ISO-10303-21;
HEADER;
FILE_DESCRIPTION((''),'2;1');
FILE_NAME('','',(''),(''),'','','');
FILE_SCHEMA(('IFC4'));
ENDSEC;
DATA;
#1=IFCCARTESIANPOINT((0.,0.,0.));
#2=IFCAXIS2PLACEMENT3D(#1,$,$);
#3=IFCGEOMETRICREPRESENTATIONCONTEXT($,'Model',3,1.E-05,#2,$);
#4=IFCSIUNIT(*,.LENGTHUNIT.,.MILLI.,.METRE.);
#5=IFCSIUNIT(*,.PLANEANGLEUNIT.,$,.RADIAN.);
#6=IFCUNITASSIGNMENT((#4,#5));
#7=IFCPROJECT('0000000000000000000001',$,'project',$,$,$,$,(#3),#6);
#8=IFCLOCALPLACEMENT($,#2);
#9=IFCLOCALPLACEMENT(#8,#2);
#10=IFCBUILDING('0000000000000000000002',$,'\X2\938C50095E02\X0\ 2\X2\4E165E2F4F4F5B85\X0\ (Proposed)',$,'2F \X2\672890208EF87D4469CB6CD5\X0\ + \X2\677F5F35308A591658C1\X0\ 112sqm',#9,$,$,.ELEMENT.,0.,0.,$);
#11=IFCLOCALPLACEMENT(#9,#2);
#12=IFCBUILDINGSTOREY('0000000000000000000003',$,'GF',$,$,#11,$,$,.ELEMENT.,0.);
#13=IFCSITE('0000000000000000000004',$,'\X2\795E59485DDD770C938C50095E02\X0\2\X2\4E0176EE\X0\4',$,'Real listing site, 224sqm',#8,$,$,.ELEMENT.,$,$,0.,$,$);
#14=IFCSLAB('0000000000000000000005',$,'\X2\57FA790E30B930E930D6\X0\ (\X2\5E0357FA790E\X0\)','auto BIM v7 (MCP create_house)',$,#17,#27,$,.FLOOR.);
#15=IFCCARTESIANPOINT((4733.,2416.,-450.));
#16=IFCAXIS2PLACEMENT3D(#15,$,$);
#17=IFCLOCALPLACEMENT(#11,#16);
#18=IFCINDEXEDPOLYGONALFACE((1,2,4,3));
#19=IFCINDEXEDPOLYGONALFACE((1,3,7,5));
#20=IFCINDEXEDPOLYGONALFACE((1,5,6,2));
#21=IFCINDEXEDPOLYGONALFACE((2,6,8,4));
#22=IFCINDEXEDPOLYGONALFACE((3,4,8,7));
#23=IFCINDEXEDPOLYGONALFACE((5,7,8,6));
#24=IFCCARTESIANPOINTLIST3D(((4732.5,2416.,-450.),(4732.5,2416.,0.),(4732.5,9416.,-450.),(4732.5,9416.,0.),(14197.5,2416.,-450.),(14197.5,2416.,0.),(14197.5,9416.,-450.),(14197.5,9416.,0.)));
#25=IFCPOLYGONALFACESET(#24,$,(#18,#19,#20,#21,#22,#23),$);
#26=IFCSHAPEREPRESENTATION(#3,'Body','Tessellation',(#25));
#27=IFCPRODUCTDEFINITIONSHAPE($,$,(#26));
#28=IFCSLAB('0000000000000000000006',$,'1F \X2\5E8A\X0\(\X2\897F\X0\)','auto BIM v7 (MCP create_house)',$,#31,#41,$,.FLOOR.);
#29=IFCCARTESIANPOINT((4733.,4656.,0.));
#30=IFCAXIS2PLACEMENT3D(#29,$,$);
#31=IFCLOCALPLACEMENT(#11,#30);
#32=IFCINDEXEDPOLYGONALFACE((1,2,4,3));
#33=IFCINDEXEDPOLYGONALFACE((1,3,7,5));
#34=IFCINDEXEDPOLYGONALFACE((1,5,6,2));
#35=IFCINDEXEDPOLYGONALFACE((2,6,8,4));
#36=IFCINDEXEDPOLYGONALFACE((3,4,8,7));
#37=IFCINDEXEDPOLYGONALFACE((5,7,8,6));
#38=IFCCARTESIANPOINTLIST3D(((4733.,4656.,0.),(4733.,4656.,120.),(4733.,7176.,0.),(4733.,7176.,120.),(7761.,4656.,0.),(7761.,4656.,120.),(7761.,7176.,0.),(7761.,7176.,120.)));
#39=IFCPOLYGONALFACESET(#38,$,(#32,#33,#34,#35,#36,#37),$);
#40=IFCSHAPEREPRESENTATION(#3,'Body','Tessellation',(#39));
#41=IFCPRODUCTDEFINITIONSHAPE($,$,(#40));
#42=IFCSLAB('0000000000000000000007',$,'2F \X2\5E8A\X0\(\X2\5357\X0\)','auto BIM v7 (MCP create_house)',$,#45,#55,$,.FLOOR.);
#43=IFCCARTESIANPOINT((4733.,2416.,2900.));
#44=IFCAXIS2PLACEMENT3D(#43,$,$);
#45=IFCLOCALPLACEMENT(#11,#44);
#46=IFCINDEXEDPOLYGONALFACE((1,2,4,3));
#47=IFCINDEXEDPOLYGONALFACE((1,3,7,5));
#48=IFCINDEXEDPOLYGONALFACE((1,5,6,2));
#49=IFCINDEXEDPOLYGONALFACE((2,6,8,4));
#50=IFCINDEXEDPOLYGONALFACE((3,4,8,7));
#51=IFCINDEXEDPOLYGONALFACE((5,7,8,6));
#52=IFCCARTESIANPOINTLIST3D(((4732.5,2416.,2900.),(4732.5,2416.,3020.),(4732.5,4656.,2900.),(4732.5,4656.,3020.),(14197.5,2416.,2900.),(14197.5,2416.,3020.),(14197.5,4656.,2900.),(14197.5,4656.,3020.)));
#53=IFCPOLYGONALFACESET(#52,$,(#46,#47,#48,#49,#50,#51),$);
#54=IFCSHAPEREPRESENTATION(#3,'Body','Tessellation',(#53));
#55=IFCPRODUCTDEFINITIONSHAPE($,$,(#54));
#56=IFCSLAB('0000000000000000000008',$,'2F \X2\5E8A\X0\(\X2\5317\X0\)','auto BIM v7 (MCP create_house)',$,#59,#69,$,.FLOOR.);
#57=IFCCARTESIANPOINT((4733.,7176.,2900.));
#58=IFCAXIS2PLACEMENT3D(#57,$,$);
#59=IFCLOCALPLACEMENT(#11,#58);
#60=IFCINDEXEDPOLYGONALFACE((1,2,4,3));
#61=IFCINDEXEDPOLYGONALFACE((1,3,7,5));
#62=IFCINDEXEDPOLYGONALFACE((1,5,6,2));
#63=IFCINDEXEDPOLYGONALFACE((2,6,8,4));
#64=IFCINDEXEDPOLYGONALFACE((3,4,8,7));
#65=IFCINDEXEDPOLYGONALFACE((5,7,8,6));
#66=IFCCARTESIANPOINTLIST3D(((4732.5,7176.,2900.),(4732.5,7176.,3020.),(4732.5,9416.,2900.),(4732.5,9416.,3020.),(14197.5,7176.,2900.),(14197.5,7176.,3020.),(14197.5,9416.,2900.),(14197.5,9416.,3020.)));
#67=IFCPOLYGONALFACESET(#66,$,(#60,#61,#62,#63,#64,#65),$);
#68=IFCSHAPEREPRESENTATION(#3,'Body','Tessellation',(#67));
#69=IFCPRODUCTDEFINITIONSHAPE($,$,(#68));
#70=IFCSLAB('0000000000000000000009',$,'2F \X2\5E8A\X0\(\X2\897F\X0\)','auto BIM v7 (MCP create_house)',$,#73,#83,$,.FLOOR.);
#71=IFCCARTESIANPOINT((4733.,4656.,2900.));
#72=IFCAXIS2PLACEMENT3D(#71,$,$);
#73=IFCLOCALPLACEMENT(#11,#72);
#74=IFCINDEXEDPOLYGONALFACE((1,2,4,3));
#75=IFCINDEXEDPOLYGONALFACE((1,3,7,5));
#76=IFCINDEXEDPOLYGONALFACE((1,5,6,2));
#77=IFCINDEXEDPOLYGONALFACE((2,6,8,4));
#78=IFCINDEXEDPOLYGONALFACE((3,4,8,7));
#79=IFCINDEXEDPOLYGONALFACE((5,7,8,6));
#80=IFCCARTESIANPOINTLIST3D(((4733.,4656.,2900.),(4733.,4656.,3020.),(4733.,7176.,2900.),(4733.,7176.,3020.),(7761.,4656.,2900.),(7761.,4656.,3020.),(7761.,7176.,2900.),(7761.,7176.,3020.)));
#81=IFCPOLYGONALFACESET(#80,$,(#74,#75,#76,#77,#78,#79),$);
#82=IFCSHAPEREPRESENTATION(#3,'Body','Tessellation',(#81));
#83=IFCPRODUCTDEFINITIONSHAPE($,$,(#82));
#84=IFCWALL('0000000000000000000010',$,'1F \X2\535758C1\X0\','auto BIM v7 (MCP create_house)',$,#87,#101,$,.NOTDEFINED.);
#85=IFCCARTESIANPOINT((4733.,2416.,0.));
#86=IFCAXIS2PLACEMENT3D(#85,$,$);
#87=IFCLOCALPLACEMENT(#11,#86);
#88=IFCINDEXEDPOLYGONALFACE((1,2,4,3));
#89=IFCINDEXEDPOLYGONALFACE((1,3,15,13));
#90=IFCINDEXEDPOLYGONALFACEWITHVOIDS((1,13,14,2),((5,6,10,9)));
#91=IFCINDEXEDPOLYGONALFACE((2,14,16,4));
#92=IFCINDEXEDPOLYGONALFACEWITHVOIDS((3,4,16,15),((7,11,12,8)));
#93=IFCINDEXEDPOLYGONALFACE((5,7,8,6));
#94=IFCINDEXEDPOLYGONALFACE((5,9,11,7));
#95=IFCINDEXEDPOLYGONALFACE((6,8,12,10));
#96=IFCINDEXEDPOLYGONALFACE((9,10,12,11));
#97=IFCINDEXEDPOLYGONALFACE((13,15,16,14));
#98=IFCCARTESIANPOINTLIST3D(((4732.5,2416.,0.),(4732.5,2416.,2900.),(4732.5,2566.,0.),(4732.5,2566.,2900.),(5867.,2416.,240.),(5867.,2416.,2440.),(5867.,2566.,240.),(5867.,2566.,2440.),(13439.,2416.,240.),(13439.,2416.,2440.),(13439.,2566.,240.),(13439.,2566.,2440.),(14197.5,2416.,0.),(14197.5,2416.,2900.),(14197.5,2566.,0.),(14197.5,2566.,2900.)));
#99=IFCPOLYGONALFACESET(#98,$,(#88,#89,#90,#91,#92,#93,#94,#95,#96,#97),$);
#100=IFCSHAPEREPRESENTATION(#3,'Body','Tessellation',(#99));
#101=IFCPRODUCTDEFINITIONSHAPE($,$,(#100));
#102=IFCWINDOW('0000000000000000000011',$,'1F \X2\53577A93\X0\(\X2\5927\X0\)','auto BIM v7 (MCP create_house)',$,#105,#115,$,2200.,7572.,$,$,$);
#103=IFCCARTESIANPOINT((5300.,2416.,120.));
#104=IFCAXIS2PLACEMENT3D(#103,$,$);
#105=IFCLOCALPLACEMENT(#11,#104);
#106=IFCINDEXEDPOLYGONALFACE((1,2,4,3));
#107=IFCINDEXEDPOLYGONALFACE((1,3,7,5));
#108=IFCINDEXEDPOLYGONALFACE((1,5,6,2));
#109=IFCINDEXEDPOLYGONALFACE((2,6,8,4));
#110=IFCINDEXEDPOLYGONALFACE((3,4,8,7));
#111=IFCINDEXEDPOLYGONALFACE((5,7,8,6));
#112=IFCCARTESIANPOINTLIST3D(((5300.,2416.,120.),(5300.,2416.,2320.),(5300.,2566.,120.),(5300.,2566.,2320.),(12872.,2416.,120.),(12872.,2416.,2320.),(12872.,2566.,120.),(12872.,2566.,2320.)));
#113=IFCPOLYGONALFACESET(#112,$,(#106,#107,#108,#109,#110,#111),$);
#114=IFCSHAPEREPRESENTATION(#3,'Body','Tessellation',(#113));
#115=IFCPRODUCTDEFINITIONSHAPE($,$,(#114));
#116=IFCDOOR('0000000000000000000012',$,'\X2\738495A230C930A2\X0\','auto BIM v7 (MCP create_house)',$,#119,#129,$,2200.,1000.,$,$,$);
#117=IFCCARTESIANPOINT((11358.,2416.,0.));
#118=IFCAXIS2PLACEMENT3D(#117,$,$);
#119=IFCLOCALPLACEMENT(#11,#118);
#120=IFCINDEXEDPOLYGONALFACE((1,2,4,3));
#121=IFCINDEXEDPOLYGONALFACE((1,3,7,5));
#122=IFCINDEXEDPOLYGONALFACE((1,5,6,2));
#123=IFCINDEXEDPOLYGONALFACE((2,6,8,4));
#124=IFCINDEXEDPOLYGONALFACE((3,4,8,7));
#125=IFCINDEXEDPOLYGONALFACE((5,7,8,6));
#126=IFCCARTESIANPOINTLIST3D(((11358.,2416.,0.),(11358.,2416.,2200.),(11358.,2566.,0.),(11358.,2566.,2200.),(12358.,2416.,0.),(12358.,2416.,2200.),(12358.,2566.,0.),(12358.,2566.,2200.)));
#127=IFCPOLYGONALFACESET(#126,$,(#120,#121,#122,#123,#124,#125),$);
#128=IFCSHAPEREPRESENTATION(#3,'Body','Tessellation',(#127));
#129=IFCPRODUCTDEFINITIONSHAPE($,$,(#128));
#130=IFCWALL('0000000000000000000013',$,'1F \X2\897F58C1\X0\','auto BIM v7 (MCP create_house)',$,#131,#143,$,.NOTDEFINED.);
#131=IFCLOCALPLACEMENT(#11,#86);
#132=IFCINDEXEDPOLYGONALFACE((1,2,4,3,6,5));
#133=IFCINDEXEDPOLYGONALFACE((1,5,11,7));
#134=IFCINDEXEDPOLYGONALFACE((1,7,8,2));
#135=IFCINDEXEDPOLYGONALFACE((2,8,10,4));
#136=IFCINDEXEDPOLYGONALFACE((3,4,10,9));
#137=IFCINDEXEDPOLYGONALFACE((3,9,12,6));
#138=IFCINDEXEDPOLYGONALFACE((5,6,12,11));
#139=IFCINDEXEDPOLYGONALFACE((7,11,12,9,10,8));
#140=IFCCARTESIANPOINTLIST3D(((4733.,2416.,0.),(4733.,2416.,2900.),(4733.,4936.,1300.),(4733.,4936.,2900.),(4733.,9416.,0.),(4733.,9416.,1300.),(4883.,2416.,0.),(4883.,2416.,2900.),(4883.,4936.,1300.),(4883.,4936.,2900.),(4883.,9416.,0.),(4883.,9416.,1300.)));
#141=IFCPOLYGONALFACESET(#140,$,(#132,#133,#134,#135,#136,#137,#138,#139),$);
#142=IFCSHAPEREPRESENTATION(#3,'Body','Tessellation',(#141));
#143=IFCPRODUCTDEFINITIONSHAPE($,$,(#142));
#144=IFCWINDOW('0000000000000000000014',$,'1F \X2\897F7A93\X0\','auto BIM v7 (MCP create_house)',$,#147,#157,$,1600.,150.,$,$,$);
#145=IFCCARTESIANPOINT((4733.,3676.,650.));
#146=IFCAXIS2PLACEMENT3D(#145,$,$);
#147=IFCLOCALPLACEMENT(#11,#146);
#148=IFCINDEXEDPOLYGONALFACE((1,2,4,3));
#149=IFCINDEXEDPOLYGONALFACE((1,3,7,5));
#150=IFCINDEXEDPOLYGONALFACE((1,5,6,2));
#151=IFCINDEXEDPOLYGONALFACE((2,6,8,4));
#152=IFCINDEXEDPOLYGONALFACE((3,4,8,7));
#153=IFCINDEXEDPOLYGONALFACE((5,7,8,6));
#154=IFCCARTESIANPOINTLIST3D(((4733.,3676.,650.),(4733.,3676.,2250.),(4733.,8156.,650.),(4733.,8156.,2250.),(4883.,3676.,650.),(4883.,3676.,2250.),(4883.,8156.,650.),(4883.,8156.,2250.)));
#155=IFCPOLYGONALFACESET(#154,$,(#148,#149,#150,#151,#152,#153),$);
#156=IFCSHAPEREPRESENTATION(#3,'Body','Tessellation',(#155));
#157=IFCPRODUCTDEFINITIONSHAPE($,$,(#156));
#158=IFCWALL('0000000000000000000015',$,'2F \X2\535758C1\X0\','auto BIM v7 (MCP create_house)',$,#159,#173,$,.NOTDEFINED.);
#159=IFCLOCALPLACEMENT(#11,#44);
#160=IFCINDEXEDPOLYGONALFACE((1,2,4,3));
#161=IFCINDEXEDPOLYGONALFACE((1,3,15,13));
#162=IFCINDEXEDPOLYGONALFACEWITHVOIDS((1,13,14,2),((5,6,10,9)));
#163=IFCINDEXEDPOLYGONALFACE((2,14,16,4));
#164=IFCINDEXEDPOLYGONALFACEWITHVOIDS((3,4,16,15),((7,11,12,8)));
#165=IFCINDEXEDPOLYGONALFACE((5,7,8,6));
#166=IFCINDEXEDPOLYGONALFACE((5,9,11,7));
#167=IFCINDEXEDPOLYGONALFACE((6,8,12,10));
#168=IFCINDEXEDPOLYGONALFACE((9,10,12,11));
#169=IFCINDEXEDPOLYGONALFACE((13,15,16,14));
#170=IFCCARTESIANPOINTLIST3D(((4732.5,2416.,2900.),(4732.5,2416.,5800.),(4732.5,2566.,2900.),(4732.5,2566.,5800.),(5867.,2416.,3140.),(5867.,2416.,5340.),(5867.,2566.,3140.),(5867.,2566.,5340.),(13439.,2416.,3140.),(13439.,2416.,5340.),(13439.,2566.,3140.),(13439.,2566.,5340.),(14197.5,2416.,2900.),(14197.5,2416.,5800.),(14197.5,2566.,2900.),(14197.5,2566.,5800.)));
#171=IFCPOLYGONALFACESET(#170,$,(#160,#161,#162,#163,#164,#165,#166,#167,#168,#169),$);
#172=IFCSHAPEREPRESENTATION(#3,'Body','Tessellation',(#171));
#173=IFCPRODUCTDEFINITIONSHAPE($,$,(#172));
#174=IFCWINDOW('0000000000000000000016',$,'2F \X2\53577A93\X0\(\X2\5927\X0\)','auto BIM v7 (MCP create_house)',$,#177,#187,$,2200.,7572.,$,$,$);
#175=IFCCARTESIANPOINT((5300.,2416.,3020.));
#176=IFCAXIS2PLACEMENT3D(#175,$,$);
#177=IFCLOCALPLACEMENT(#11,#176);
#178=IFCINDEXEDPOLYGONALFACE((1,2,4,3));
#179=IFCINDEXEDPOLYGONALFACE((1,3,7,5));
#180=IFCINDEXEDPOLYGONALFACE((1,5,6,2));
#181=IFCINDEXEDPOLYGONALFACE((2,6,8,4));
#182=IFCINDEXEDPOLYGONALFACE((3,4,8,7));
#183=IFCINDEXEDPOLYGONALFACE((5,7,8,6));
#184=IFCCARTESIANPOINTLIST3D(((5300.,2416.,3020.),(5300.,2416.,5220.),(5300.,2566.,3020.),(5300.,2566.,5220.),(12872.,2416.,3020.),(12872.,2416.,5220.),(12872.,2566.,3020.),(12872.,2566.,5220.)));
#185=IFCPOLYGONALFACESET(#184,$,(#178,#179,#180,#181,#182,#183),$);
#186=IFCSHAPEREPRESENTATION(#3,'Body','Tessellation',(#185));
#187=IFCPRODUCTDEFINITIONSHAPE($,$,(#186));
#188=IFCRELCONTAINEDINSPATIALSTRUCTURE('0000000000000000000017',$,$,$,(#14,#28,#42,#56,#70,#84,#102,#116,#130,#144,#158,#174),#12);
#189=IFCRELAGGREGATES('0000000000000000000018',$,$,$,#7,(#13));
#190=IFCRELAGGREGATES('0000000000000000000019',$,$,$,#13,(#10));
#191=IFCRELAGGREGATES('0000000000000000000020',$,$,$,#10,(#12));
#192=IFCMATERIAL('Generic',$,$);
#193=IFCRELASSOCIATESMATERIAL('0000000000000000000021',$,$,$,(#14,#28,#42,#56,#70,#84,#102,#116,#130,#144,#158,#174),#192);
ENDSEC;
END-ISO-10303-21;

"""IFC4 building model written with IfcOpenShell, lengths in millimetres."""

from ifc_helpers import new_model, si_unit, frame, frame_2d, origin, place, context, project, spatial, rectangle, extrude, material, element, fill, save


model = new_model("IFC4")

# Units and contexts
model_context = context("Model", 3, precision=1e-05, world=origin())
ifc_project = project(units=[si_unit("LENGTHUNIT", "METRE", prefix="MILLI"), si_unit("PLANEANGLEUNIT", "RADIAN")], contexts=[model_context])

# Site, building, storey
site_placement = place(None, origin())
site = spatial("IfcSite", under=ifc_project, at=site_placement, Name="神奈川県鎌倉市2丁目4", ObjectType="Real listing site, 224sqm", CompositionType="ELEMENT", RefElevation=0.0)
building_placement = place(site_placement, origin())
building = spatial("IfcBuilding", under=site, at=building_placement, Name="鎌倉市 2世帯住宅 (Proposed)", ObjectType="2F 木造軸組構法 + 板張り外壁 112sqm", CompositionType="ELEMENT", ElevationOfRefHeight=0.0, ElevationOfTerrain=0.0)
storey_placement = place(building_placement, origin())
storey = spatial("IfcBuildingStorey", under=building, at=storey_placement, Name="GF", CompositionType="ELEMENT", Elevation=0.0)

# Slabs
ifc_material = material(Name="Generic")
slab_1_placement = place(storey_placement, frame((4733.0, 2416.0, -450.0)))
element("IfcSlab", 1, at=slab_1_placement, inside=storey, material=ifc_material, Name="基礎スラブ (布基礎)", Description="auto BIM v7 (MCP create_house)", PredefinedType="FLOOR", context=model_context, shape_type="SweptSolid", body=[
    extrude(rectangle(XDim=9465.0, YDim=7000.0, at=frame_2d((4732.0, 3500.0))), frame((4733.0, 2416.0, -450.0)), (0.0, 0.0, 1.0), 450.0),
])
slab_2_placement = place(storey_placement, frame((4733.0, 4656.0, 0.0)))
element("IfcSlab", 2, at=slab_2_placement, inside=storey, material=ifc_material, Name="1F 床(西)", Description="auto BIM v7 (MCP create_house)", PredefinedType="FLOOR", context=model_context, shape_type="SweptSolid", body=[
    extrude(rectangle(XDim=3028.0, YDim=2520.0, at=frame_2d((1514.0, 1260.0))), frame((4733.0, 4656.0, 0.0)), (0.0, 0.0, 1.0), 120.0),
])
slab_3_placement = place(storey_placement, frame((4733.0, 2416.0, 2900.0)))
element("IfcSlab", 3, at=slab_3_placement, inside=storey, material=ifc_material, Name="2F 床(南)", Description="auto BIM v7 (MCP create_house)", PredefinedType="FLOOR", context=model_context, shape_type="SweptSolid", body=[
    extrude(rectangle(XDim=9465.0, YDim=2240.0, at=frame_2d((4732.0, 1120.0))), frame((4733.0, 2416.0, 2900.0)), (0.0, 0.0, 1.0), 120.0),
])
slab_4_placement = place(storey_placement, frame((4733.0, 7176.0, 2900.0)))
element("IfcSlab", 4, at=slab_4_placement, inside=storey, material=ifc_material, Name="2F 床(北)", Description="auto BIM v7 (MCP create_house)", PredefinedType="FLOOR", context=model_context, shape_type="SweptSolid", body=[
    extrude(rectangle(XDim=9465.0, YDim=2240.0, at=frame_2d((4732.0, 1120.0))), frame((4733.0, 7176.0, 2900.0)), (0.0, 0.0, 1.0), 120.0),
])
slab_5_placement = place(storey_placement, frame((4733.0, 4656.0, 2900.0)))
element("IfcSlab", 5, at=slab_5_placement, inside=storey, material=ifc_material, Name="2F 床(西)", Description="auto BIM v7 (MCP create_house)", PredefinedType="FLOOR", context=model_context, shape_type="SweptSolid", body=[
    extrude(rectangle(XDim=3028.0, YDim=2520.0, at=frame_2d((1514.0, 1260.0))), frame((4733.0, 4656.0, 2900.0)), (0.0, 0.0, 1.0), 120.0),
])

# Wall, openings, window, door
wall_1_placement = place(storey_placement, frame((4733.0, 2416.0, 0.0)))
wall_1 = element("IfcWall", 6, at=wall_1_placement, inside=storey, material=ifc_material, Name="1F 南壁", Description="auto BIM v7 (MCP create_house)", PredefinedType="NOTDEFINED", context=model_context, shape_type="SweptSolid", body=[
    extrude(rectangle(XDim=9465.0, YDim=150.0, at=frame_2d((4732.0, 75.0))), frame((4733.0, 2416.0, 0.0)), (0.0, 0.0, 1.0), 2900.0),
])
opening_1_placement = place(storey_placement, frame((5300.0, 2416.0, 120.0)))
opening_1 = element("IfcOpeningElement", 7, at=opening_1_placement, cuts=wall_1, PredefinedType="NOTDEFINED", context=model_context, shape_type="SweptSolid", body=[
    extrude(rectangle(XDim=7572.0, YDim=150.0, at=frame_2d((3786.0, 75.0))), frame((5300.0, 2416.0, 120.0)), (0.0, 0.0, 1.0), 2200.0),
])
opening_2_placement = place(storey_placement, frame((11358.0, 2416.0, 0.0)))
opening_2 = element("IfcOpeningElement", 8, at=opening_2_placement, cuts=wall_1, PredefinedType="NOTDEFINED", context=model_context, shape_type="SweptSolid", body=[
    extrude(rectangle(XDim=1000.0, YDim=150.0, at=frame_2d((500.0, 75.0))), frame((11358.0, 2416.0, 0.0)), (0.0, 0.0, 1.0), 2200.0),
])
window_1_placement = place(storey_placement, frame((5300.0, 2416.0, 120.0)))
window_1 = element("IfcWindow", 9, at=window_1_placement, inside=storey, material=ifc_material, Name="1F 南窓(大)", Description="auto BIM v7 (MCP create_house)", OverallHeight=2200.0, OverallWidth=7572.0, context=model_context, shape_type="SweptSolid", body=[
    extrude(rectangle(XDim=7572.0, YDim=150.0, at=frame_2d((3786.0, 75.0))), frame((5300.0, 2416.0, 120.0)), (0.0, 0.0, 1.0), 2200.0),
])
fill(opening_1, window_1)
door_placement = place(storey_placement, frame((11358.0, 2416.0, 0.0)))
door = element("IfcDoor", 10, at=door_placement, inside=storey, material=ifc_material, Name="玄関ドア", Description="auto BIM v7 (MCP create_house)", OverallHeight=2200.0, OverallWidth=1000.0, context=model_context, shape_type="SweptSolid", body=[
    extrude(rectangle(XDim=1000.0, YDim=150.0, at=frame_2d((500.0, 75.0))), frame((11358.0, 2416.0, 0.0)), (0.0, 0.0, 1.0), 2200.0),
])
fill(opening_2, door)

# Walls, openings, windows
wall_2_placement = place(storey_placement, frame((4733.0, 2416.0, 0.0)))
wall_2 = element("IfcWall", 11, at=wall_2_placement, inside=storey, material=ifc_material, Name="1F 西壁", Description="auto BIM v7 (MCP create_house)", PredefinedType="NOTDEFINED", context=model_context, shape_type="SweptSolid", body=[
    extrude(rectangle(XDim=150.0, YDim=7000.0, at=frame_2d((75.0, 3500.0))), frame((4733.0, 2416.0, 0.0)), (0.0, 0.0, 1.0), 2900.0),
])
opening_3_placement = place(storey_placement, frame((4733.0, 3676.0, 650.0)))
opening_3 = element("IfcOpeningElement", 12, at=opening_3_placement, cuts=wall_2, PredefinedType="NOTDEFINED", context=model_context, shape_type="SweptSolid", body=[
    extrude(rectangle(XDim=150.0, YDim=4480.0, at=frame_2d((75.0, 2240.0))), frame((4733.0, 3676.0, 650.0)), (0.0, 0.0, 1.0), 1600.0),
])
window_2_placement = place(storey_placement, frame((4733.0, 3676.0, 650.0)))
window_2 = element("IfcWindow", 13, at=window_2_placement, inside=storey, material=ifc_material, Name="1F 西窓", Description="auto BIM v7 (MCP create_house)", OverallHeight=1600.0, OverallWidth=150.0, context=model_context, shape_type="SweptSolid", body=[
    extrude(rectangle(XDim=150.0, YDim=4480.0, at=frame_2d((75.0, 2240.0))), frame((4733.0, 3676.0, 650.0)), (0.0, 0.0, 1.0), 1600.0),
])
fill(opening_3, window_2)
wall_3_placement = place(storey_placement, frame((4733.0, 2416.0, 2900.0)))
wall_3 = element("IfcWall", 14, at=wall_3_placement, inside=storey, material=ifc_material, Name="2F 南壁", Description="auto BIM v7 (MCP create_house)", PredefinedType="NOTDEFINED", context=model_context, shape_type="SweptSolid", body=[
    extrude(rectangle(XDim=9465.0, YDim=150.0, at=frame_2d((4732.0, 75.0))), frame((4733.0, 2416.0, 2900.0)), (0.0, 0.0, 1.0), 2900.0),
])
opening_4_placement = place(storey_placement, frame((5300.0, 2416.0, 3020.0)))
opening_4 = element("IfcOpeningElement", 15, at=opening_4_placement, cuts=wall_3, PredefinedType="NOTDEFINED", context=model_context, shape_type="SweptSolid", body=[
    extrude(rectangle(XDim=7572.0, YDim=150.0, at=frame_2d((3786.0, 75.0))), frame((5300.0, 2416.0, 3020.0)), (0.0, 0.0, 1.0), 2200.0),
])
window_3_placement = place(storey_placement, frame((5300.0, 2416.0, 3020.0)))
window_3 = element("IfcWindow", 16, at=window_3_placement, inside=storey, material=ifc_material, Name="2F 南窓(大)", Description="auto BIM v7 (MCP create_house)", OverallHeight=2200.0, OverallWidth=7572.0, context=model_context, shape_type="SweptSolid", body=[
    extrude(rectangle(XDim=7572.0, YDim=150.0, at=frame_2d((3786.0, 75.0))), frame((5300.0, 2416.0, 3020.0)), (0.0, 0.0, 1.0), 2200.0),
])
fill(opening_4, window_3)

save(model, "model.ifc")
